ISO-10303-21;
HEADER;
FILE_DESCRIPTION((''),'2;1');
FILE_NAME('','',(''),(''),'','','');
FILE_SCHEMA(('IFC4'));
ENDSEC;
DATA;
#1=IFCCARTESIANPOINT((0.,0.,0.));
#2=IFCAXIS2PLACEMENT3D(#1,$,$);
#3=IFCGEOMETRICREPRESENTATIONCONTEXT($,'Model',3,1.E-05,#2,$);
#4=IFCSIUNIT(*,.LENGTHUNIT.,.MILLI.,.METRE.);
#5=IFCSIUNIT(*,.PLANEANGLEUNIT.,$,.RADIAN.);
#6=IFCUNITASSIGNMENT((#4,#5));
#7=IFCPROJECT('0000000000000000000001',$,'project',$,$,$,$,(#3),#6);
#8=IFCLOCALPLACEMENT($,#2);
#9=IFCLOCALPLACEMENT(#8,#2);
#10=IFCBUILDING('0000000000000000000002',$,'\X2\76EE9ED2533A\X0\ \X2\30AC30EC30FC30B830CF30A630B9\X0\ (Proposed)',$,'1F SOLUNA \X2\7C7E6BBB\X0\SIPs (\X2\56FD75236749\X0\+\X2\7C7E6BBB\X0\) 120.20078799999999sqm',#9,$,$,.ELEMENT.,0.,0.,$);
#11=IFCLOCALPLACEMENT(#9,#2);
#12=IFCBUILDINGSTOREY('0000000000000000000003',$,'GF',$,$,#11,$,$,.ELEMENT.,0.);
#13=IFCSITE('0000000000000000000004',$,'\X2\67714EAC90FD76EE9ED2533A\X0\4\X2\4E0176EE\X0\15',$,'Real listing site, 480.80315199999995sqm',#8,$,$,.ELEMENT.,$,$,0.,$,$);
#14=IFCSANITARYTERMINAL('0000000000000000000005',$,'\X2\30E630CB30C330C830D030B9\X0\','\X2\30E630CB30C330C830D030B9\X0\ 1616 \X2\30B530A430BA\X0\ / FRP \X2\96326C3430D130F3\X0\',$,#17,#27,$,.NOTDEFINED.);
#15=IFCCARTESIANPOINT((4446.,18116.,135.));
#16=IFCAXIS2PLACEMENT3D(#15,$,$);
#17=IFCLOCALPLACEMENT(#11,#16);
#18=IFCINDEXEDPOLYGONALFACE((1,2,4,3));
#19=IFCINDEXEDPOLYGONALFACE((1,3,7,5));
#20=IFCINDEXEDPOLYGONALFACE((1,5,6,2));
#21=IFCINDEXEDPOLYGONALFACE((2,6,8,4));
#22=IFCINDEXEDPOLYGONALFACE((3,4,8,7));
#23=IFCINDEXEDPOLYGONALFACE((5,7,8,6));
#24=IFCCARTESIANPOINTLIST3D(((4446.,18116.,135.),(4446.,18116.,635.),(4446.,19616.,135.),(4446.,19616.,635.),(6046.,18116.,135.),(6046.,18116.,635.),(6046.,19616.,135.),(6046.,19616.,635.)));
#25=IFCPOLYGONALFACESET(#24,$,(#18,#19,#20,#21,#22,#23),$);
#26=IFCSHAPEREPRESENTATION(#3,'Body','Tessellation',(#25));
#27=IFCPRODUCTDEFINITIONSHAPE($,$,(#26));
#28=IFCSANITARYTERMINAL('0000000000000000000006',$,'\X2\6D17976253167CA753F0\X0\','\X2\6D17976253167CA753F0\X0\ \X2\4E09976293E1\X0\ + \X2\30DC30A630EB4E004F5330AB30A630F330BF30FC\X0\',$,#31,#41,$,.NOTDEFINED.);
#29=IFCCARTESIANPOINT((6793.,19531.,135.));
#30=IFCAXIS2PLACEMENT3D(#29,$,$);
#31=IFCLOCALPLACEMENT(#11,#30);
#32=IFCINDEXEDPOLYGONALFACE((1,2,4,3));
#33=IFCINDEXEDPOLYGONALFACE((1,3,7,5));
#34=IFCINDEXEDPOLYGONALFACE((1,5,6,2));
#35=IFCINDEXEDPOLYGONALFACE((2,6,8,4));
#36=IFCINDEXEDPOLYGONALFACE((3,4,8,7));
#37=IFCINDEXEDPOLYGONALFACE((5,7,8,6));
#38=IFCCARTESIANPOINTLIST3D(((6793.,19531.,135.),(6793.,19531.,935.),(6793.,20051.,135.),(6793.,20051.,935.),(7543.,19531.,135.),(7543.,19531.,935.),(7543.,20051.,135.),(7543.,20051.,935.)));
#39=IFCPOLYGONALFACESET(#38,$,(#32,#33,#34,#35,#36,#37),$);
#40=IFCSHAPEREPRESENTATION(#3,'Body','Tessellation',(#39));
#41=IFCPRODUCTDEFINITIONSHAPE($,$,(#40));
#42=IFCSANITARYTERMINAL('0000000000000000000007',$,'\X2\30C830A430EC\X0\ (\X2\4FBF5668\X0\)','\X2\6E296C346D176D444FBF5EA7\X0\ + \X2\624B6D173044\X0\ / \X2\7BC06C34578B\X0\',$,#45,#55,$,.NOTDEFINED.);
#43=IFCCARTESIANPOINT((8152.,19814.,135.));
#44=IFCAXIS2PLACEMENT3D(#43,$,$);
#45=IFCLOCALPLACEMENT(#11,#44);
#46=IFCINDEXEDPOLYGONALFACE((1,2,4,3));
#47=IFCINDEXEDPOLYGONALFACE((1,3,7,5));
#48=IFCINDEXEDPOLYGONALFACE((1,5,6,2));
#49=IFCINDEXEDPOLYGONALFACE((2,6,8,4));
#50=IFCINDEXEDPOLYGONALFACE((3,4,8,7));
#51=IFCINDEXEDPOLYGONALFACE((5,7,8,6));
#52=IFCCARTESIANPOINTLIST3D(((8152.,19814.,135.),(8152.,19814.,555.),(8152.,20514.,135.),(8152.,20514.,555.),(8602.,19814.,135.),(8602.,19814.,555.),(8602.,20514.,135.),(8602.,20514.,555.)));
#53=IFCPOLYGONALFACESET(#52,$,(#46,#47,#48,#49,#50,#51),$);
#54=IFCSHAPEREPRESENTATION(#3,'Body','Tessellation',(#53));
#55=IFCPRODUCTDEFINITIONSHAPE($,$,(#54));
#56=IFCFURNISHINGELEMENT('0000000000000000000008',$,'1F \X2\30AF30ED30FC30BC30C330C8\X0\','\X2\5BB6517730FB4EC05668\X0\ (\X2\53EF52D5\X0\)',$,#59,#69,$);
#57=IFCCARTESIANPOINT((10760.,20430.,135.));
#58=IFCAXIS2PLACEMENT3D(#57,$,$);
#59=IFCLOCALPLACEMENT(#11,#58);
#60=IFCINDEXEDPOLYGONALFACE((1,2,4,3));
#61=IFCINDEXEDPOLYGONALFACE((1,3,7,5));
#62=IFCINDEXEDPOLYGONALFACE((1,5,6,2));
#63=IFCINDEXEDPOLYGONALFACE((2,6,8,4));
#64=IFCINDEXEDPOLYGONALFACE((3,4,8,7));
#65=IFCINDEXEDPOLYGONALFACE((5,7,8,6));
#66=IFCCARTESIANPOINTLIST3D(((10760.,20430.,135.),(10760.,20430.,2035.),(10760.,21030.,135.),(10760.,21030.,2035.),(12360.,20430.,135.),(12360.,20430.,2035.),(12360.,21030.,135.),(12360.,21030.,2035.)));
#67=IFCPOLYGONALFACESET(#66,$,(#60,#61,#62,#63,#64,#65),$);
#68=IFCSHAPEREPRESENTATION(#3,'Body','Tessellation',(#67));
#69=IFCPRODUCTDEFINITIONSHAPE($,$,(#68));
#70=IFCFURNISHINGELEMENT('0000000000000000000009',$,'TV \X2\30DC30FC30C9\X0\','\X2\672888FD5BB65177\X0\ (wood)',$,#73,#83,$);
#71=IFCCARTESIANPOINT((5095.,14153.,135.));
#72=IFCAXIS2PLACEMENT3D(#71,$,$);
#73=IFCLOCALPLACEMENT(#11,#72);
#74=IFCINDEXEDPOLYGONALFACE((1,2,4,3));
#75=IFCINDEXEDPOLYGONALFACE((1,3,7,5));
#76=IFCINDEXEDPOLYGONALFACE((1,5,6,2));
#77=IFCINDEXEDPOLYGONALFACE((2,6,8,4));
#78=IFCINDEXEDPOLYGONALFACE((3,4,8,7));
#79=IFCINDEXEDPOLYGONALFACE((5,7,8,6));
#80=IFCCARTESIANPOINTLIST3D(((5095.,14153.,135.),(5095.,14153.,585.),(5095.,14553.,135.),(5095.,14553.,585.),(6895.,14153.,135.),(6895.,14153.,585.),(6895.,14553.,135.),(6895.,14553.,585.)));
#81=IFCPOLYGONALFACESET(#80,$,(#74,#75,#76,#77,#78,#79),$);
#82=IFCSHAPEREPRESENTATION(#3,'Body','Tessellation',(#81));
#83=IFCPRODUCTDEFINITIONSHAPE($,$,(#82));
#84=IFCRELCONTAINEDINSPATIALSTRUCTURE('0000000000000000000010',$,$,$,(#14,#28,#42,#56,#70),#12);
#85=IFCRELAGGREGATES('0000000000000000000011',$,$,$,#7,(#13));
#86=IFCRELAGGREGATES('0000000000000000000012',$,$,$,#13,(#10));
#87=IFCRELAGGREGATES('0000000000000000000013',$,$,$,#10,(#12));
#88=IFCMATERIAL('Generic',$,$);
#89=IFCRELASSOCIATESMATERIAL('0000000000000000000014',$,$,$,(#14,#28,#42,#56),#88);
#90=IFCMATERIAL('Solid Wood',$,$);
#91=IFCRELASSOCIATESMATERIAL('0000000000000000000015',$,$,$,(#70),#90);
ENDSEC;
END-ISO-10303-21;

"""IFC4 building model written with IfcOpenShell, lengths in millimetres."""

from ifc_helpers import new_model, si_unit, frame, frame_2d, origin, place, context, project, spatial, rectangle, extrude, material, element, save


model = new_model("IFC4")

# Units and contexts
model_context = context("Model", 3, precision=1e-05, world=origin())
ifc_project = project(units=[si_unit("LENGTHUNIT", "METRE", prefix="MILLI"), si_unit("PLANEANGLEUNIT", "RADIAN")], contexts=[model_context])

# Site, building, storey
site_placement = place(None, origin())
site = spatial("IfcSite", under=ifc_project, at=site_placement, Name="東京都目黒区4丁目15", ObjectType="Real listing site, 480.80315199999995sqm", CompositionType="ELEMENT", RefElevation=0.0)
building_placement = place(site_placement, origin())
building = spatial("IfcBuilding", under=site, at=building_placement, Name="目黒区 ガレージハウス (Proposed)", ObjectType="1F SOLUNA 籾殻SIPs (国産杉+籾殻) 120.20078799999999sqm", CompositionType="ELEMENT", ElevationOfRefHeight=0.0, ElevationOfTerrain=0.0)
storey_placement = place(building_placement, origin())
storey = spatial("IfcBuildingStorey", under=building, at=storey_placement, Name="GF", CompositionType="ELEMENT", Elevation=0.0)

# Shared definitions
ifc_material_1 = material(Name="Solid Wood")

# Sanitary terminals
ifc_material_2 = material(Name="Generic")
sanitary_terminal_1_placement = place(storey_placement, frame((4446.0, 18116.0, 135.0)))
element("IfcSanitaryTerminal", 1, at=sanitary_terminal_1_placement, inside=storey, material=ifc_material_2, Name="ユニットバス", Description="ユニットバス 1616 サイズ / FRP 防水パン", PredefinedType="NOTDEFINED", context=model_context, shape_type="SweptSolid", body=[
    extrude(rectangle(XDim=1600.0, YDim=1500.0, at=frame_2d((800.0, 750.0))), frame((4446.0, 18116.0, 135.0)), (0.0, 0.0, 1.0), 500.0),
])
sanitary_terminal_2_placement = place(storey_placement, frame((6793.0, 19531.0, 135.0)))
element("IfcSanitaryTerminal", 2, at=sanitary_terminal_2_placement, inside=storey, material=ifc_material_2, Name="洗面化粧台", Description="洗面化粧台 三面鏡 + ボウル一体カウンター", PredefinedType="NOTDEFINED", context=model_context, shape_type="SweptSolid", body=[
    extrude(rectangle(XDim=750.0, YDim=520.0, at=frame_2d((375.0, 260.0))), frame((6793.0, 19531.0, 135.0)), (0.0, 0.0, 1.0), 800.0),
])
sanitary_terminal_3_placement = place(storey_placement, frame((8152.0, 19814.0, 135.0)))
element("IfcSanitaryTerminal", 3, at=sanitary_terminal_3_placement, inside=storey, material=ifc_material_2, Name="トイレ (便器)", Description="温水洗浄便座 + 手洗い / 節水型", PredefinedType="NOTDEFINED", context=model_context, shape_type="SweptSolid", body=[
    extrude(rectangle(XDim=450.0, YDim=700.0, at=frame_2d((225.0, 350.0))), frame((8152.0, 19814.0, 135.0)), (0.0, 0.0, 1.0), 420.0),
])

# Furnishing elements
furnishing_1_placement = place(storey_placement, frame((10760.0, 20430.0, 135.0)))
element("IfcFurnishingElement", 4, at=furnishing_1_placement, inside=storey, material=ifc_material_2, Name="1F クローゼット", Description="家具・什器 (可動)", context=model_context, shape_type="SweptSolid", body=[
    extrude(rectangle(XDim=1600.0, YDim=600.0, at=frame_2d((800.0, 300.0))), frame((10760.0, 20430.0, 135.0)), (0.0, 0.0, 1.0), 1900.0),
])
furnishing_2_placement = place(storey_placement, frame((5095.0, 14153.0, 135.0)))
element("IfcFurnishingElement", 5, at=furnishing_2_placement, inside=storey, material=ifc_material_1, Name="TV ボード", Description="木製家具 (wood)", context=model_context, shape_type="SweptSolid", body=[
    extrude(rectangle(XDim=1800.0, YDim=400.0, at=frame_2d((900.0, 200.0))), frame((5095.0, 14153.0, 135.0)), (0.0, 0.0, 1.0), 450.0),
])

save(model, "model.ifc")
